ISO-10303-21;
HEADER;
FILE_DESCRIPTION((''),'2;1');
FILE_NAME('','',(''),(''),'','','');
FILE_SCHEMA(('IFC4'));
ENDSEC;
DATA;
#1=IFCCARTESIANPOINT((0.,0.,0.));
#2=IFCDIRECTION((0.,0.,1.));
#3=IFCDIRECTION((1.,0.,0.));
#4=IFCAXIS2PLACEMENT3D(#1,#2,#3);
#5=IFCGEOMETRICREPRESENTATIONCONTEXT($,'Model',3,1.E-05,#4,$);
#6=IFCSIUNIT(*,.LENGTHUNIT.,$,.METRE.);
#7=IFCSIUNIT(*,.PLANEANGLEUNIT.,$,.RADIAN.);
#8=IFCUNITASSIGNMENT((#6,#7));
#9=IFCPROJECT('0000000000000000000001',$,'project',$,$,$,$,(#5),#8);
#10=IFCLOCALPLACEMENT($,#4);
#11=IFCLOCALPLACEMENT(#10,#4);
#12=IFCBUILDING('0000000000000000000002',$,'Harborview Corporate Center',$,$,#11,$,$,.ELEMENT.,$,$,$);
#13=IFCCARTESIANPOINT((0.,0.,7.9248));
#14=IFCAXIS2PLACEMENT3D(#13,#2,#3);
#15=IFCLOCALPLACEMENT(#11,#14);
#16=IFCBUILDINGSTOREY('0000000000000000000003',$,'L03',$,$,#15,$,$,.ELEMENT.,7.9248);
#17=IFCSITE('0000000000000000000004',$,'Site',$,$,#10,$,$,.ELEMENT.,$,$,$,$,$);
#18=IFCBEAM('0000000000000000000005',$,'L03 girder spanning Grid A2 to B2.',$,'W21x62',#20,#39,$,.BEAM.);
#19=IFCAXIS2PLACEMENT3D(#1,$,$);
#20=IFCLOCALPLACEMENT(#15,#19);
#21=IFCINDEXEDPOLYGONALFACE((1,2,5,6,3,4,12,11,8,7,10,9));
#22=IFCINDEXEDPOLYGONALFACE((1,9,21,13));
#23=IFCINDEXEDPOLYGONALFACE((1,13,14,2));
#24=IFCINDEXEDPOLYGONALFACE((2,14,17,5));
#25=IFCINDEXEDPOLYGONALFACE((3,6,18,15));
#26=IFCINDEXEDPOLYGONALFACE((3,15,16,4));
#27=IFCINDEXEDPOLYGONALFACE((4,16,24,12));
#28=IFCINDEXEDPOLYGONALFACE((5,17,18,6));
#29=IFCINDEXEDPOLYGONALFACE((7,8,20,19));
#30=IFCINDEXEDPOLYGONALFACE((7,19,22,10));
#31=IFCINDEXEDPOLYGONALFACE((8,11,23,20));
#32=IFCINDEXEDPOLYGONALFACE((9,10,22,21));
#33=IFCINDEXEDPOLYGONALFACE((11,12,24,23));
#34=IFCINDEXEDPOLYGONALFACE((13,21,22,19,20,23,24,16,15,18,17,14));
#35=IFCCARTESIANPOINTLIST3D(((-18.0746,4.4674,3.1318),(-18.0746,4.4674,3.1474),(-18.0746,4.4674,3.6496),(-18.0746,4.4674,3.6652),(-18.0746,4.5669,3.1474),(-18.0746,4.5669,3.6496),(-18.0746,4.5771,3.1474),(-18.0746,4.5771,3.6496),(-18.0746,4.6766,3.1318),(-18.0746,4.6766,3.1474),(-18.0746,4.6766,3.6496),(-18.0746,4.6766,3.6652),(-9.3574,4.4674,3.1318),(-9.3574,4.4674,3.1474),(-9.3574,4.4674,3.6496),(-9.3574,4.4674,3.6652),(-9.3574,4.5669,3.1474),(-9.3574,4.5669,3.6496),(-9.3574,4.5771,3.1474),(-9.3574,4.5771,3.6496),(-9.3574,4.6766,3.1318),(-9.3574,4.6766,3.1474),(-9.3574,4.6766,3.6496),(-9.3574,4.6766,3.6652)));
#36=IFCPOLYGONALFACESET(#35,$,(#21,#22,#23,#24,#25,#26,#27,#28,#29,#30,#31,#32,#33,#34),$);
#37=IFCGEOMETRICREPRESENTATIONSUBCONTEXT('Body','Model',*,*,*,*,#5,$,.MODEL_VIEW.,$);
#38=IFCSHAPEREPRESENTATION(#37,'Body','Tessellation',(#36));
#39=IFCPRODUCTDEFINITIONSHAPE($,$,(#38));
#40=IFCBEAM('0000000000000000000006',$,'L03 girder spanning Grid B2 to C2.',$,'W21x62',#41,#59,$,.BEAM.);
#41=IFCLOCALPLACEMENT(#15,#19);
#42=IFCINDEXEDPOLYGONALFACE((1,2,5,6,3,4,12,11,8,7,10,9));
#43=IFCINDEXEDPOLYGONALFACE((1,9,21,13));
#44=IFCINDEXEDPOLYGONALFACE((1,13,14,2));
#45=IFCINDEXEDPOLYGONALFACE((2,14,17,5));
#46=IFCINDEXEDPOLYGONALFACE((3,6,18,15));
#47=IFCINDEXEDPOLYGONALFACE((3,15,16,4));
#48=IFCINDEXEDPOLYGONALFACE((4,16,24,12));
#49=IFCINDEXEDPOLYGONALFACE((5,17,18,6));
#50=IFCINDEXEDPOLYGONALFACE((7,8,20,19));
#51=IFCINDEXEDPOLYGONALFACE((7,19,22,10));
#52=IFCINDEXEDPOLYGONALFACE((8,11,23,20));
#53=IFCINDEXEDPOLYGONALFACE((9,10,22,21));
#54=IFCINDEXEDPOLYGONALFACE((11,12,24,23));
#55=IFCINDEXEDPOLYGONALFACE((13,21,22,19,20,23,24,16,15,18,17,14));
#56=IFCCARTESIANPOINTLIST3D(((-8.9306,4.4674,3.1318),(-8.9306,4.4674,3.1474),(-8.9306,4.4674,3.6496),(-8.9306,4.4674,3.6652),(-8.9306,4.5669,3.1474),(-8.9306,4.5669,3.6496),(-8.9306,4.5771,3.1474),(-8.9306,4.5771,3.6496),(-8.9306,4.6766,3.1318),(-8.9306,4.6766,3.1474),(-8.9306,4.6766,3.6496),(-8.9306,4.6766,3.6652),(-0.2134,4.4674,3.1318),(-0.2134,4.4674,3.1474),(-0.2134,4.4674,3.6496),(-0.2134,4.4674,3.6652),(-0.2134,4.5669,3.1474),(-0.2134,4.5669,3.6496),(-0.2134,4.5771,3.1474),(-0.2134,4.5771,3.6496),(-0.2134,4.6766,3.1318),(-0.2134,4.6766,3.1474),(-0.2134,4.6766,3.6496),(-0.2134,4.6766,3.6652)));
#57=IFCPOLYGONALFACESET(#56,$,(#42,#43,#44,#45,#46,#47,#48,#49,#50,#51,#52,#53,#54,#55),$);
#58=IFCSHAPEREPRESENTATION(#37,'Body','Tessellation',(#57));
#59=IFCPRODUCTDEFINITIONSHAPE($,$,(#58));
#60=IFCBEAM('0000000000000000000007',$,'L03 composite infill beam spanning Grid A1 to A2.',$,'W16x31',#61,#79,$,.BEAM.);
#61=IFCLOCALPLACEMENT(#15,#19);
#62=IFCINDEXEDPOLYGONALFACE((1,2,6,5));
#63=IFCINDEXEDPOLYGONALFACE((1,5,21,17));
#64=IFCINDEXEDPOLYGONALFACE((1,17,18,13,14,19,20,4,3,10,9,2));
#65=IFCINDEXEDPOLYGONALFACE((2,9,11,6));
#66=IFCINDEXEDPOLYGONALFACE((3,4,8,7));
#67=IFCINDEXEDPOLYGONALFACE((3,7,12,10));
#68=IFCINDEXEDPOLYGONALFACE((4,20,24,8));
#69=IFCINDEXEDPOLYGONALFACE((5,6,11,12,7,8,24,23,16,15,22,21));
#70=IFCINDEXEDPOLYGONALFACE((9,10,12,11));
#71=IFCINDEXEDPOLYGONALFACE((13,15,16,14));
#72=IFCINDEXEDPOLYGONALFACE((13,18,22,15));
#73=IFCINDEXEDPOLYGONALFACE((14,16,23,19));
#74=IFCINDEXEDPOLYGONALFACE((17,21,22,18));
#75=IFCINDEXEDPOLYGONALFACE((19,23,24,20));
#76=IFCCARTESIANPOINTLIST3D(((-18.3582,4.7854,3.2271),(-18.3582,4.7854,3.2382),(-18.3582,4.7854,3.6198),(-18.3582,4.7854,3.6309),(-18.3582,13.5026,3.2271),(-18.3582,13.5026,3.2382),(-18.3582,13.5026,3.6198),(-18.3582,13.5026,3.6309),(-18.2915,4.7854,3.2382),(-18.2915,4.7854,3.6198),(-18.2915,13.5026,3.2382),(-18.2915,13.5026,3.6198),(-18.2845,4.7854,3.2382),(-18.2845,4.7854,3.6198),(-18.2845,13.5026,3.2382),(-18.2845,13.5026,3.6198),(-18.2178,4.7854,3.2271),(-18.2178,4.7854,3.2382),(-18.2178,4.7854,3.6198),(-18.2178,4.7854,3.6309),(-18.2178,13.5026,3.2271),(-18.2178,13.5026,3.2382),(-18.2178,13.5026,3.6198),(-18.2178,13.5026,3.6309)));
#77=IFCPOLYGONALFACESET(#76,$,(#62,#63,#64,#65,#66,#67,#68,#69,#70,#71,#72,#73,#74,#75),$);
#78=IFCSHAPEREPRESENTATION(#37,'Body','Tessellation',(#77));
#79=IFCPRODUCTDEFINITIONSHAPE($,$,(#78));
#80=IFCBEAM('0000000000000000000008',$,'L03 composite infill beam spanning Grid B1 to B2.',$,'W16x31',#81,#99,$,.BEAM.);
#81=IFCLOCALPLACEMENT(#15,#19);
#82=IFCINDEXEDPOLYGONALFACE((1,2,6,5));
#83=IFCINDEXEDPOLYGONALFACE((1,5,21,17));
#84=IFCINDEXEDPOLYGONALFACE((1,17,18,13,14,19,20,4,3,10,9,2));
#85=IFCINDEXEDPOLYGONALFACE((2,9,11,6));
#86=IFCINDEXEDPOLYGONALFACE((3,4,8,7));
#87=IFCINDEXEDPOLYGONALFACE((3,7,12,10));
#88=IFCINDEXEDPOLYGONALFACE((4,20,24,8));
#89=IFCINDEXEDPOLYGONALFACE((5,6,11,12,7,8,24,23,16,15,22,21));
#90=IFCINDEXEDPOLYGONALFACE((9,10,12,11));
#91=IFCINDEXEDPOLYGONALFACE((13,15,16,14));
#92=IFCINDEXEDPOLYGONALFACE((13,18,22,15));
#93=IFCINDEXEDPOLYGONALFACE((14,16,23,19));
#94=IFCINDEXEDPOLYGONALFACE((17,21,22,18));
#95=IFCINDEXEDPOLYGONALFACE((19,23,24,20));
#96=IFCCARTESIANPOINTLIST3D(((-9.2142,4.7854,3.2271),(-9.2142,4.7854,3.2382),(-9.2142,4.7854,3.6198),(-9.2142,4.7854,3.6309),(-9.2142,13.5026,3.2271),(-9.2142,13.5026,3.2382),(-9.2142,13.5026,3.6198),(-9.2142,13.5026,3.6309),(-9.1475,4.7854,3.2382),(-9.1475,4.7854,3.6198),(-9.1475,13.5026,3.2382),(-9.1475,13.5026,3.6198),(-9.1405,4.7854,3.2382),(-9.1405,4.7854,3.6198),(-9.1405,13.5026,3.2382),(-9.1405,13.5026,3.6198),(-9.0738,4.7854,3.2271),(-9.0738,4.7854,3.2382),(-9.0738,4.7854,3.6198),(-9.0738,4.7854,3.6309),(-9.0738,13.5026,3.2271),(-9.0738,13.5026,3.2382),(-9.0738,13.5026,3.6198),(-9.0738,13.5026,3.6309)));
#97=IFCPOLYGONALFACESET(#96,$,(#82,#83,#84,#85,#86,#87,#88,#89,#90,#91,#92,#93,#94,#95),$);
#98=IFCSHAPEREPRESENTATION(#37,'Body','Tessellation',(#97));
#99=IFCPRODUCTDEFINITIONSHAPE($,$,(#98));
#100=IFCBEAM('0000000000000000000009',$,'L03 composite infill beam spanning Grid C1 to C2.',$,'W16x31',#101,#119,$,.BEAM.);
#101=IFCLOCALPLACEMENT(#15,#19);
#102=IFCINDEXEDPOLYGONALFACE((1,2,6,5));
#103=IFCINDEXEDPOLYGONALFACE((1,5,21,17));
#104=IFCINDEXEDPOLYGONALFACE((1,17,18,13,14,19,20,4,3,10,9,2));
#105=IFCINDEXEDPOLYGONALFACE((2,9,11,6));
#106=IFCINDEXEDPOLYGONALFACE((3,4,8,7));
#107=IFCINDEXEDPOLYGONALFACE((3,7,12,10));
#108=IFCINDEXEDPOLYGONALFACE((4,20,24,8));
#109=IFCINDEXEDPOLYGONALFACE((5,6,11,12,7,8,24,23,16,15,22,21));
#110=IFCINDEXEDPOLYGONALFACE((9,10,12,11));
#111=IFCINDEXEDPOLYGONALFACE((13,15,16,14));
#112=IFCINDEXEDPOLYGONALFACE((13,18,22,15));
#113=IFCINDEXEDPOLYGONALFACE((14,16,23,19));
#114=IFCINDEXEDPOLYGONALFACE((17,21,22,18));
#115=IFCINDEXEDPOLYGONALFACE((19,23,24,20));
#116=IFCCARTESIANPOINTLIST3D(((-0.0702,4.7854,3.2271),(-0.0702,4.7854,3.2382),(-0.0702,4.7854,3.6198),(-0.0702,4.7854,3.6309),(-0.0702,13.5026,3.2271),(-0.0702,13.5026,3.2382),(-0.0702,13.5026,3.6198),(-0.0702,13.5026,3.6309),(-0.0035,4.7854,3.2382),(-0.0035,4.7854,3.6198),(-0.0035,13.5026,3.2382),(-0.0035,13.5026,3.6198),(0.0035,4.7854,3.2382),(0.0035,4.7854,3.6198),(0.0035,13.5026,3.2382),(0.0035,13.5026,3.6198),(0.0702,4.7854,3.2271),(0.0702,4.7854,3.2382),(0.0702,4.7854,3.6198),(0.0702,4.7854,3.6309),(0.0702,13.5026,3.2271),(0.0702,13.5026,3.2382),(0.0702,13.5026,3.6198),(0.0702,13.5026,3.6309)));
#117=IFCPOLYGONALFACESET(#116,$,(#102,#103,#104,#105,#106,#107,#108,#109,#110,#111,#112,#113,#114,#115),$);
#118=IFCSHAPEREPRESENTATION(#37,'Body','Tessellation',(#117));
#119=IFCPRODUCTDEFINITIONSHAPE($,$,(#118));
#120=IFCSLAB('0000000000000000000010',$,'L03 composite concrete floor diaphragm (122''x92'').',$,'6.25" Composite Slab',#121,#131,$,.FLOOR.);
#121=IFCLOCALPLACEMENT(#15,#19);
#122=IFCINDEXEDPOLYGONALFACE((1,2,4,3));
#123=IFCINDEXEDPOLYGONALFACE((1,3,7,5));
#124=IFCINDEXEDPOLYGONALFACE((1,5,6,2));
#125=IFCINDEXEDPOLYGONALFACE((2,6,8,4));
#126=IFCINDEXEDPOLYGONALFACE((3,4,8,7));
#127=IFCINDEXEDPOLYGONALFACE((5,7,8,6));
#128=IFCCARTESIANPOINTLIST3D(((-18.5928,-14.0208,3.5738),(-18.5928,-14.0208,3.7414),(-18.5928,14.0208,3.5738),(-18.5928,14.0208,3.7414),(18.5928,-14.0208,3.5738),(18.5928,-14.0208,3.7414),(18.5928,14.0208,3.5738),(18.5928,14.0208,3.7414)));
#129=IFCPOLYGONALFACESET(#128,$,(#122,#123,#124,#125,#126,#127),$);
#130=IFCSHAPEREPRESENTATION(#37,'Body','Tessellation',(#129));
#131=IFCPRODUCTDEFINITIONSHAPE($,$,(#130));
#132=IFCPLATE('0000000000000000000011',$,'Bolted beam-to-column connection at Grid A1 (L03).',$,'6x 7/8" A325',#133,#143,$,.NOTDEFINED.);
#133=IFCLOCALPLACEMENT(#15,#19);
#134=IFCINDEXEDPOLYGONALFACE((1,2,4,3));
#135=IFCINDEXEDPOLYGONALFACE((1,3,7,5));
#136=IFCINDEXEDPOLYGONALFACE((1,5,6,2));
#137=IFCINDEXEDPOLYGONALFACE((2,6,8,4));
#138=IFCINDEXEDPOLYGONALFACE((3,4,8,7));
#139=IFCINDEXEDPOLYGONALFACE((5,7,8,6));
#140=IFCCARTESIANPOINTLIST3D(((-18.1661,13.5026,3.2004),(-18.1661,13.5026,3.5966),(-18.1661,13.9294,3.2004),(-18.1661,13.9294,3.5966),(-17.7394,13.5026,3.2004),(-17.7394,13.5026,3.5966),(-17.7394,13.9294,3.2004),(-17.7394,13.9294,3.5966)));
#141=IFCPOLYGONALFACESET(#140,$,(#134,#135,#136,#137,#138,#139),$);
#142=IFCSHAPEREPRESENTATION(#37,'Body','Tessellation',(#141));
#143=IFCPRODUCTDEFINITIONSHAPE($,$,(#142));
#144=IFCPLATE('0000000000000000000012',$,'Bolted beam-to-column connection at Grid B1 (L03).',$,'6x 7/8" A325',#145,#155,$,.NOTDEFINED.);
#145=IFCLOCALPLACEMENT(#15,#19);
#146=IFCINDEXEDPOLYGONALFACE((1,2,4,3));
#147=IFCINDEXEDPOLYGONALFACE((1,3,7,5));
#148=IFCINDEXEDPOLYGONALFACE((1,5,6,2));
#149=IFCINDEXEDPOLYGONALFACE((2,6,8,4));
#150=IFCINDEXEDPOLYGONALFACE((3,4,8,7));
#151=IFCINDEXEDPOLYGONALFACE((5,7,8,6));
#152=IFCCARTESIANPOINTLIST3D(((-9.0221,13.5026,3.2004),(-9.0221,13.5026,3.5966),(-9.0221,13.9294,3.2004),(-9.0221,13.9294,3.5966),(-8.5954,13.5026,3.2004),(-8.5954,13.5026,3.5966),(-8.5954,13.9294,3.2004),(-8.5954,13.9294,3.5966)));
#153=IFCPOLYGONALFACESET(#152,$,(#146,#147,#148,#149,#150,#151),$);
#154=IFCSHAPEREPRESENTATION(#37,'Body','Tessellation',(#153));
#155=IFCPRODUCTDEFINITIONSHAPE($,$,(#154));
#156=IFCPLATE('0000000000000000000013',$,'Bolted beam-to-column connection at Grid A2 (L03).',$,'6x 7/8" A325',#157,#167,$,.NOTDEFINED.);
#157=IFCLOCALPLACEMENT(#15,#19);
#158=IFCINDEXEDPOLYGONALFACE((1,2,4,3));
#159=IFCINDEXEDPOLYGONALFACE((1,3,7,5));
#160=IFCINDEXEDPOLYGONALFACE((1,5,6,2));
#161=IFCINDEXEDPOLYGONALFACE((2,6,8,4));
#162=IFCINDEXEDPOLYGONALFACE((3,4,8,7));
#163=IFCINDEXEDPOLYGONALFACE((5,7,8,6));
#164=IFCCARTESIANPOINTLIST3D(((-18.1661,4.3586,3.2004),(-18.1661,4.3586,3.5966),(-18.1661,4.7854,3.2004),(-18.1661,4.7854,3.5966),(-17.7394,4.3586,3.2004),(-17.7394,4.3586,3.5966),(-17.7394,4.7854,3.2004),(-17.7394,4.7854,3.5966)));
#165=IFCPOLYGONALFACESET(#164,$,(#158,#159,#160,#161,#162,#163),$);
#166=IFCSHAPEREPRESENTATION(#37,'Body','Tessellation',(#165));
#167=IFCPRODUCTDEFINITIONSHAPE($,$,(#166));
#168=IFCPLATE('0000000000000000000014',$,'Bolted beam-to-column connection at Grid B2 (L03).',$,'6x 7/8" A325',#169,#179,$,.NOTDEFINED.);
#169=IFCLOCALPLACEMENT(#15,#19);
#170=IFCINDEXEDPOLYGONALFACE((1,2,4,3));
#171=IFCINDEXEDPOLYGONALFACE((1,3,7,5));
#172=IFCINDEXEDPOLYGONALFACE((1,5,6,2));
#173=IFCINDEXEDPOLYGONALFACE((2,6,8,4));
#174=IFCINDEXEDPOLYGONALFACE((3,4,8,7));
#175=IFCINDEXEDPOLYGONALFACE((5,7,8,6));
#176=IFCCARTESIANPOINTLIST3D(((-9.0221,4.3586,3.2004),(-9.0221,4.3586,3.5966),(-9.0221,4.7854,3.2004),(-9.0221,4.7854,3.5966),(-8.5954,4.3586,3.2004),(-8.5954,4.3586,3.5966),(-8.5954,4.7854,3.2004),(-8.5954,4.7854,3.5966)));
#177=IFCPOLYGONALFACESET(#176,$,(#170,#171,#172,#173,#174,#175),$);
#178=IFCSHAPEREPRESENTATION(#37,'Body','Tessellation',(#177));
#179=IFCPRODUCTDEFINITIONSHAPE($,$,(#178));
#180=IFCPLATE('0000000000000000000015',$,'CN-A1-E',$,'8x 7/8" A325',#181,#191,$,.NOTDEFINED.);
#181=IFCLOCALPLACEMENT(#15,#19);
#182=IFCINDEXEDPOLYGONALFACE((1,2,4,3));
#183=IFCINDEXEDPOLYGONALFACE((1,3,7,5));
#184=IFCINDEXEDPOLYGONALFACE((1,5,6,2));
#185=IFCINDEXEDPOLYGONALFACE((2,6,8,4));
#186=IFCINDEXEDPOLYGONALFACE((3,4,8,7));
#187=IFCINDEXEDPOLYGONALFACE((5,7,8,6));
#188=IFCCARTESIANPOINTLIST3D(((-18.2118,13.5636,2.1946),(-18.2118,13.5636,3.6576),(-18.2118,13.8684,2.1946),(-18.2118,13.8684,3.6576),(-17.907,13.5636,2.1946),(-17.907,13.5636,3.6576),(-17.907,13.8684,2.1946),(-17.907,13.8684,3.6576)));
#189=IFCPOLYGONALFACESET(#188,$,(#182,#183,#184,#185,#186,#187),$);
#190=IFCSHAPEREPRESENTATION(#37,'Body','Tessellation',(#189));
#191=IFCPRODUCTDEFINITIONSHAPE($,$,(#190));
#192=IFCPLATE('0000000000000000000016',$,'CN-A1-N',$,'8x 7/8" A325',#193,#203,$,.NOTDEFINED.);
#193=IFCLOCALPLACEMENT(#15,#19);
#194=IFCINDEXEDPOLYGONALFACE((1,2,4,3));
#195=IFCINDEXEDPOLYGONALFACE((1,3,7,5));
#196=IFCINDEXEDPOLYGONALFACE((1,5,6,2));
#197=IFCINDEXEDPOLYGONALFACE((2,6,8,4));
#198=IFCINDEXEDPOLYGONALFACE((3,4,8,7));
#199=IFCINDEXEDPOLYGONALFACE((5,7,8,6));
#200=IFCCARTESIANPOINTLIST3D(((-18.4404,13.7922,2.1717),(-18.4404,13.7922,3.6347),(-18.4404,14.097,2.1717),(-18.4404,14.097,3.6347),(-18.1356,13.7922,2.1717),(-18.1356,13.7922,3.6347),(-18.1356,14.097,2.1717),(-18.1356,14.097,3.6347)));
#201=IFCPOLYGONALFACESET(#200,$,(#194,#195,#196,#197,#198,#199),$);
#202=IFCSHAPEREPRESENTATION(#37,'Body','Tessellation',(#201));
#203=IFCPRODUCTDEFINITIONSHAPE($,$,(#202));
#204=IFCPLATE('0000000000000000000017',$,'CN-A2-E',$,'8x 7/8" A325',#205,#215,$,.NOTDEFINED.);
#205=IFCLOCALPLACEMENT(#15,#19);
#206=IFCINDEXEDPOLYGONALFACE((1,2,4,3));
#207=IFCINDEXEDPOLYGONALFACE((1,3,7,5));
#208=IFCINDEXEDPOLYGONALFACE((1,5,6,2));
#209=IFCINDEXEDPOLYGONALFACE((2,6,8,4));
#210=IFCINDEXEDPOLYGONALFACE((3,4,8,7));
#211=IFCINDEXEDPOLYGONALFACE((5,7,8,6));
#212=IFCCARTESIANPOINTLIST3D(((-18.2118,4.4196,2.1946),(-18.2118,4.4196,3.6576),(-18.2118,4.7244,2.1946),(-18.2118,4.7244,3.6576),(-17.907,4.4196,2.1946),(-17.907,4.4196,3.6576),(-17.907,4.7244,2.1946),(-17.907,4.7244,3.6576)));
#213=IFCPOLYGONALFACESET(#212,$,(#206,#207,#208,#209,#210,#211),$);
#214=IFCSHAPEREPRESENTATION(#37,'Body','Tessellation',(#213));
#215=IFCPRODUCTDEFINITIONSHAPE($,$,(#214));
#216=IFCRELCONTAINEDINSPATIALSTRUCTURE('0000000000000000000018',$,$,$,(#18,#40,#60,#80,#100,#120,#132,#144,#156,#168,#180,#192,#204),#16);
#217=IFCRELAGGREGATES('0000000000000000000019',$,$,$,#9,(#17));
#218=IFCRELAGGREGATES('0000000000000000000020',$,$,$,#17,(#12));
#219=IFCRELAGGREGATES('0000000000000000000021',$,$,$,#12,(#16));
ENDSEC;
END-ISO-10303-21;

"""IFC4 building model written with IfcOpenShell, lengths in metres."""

from ifc_helpers import new_model, si_unit, frame, origin_with_axes, place, context, subcontext, project, spatial, rectangle, i_section, extrude, element, save


model = new_model("IFC4")

# Units and contexts
model_context = context("Model", 3, precision=1e-05, world=origin_with_axes())
body_context = subcontext(model_context, "Body", "Model", "MODEL_VIEW")
ifc_project = project(units=[si_unit("LENGTHUNIT", "METRE"), si_unit("PLANEANGLEUNIT", "RADIAN")], contexts=[model_context])

# Site, building, storey
site_placement = place(None, origin_with_axes())
site = spatial("IfcSite", under=ifc_project, at=site_placement, Name="Site", CompositionType="ELEMENT")
building_placement = place(site_placement, origin_with_axes())
building = spatial("IfcBuilding", under=site, at=building_placement, Name="Harborview Corporate Center", CompositionType="ELEMENT")
storey_placement = place(building_placement, frame((0.0, 0.0, 7.9248), z_axis=(0.0, 0.0, 1.0), x_axis=(1.0, 0.0, 0.0)))
storey = spatial("IfcBuildingStorey", under=building, at=storey_placement, Name="L03", CompositionType="ELEMENT", Elevation=7.9248)

# Beams
beam_1_placement = place(storey_placement, frame((-18.0746, 4.572, 3.3985), z_axis=(1.0, 0.0, 0.0), x_axis=(0.0, 1.0, 0.0)))
element("IfcBeam", 1, at=beam_1_placement, inside=storey, Name="L03 girder spanning Grid A2 to B2.", ObjectType="W21x62", PredefinedType="BEAM", context=body_context, shape_type="SweptSolid", body=[
    extrude(i_section(OverallWidth=0.2093, OverallDepth=0.5334, WebThickness=0.0102, FlangeThickness=0.0156), origin_with_axes(), (0.0, 0.0, 1.0), 8.7173),
])
beam_2_placement = place(storey_placement, frame((-8.9306, 4.572, 3.3985), z_axis=(1.0, 0.0, 0.0), x_axis=(0.0, 1.0, 0.0)))
element("IfcBeam", 2, at=beam_2_placement, inside=storey, Name="L03 girder spanning Grid B2 to C2.", ObjectType="W21x62", PredefinedType="BEAM", context=body_context, shape_type="SweptSolid", body=[
    extrude(i_section(OverallWidth=0.2093, OverallDepth=0.5334, WebThickness=0.0102, FlangeThickness=0.0156), origin_with_axes(), (0.0, 0.0, 1.0), 8.7173),
])
for number, where, z_axis, x_axis, name in (
    (3, (-18.288, 4.7854, 3.429), (0.0, 1.0, 0.0), (-1.0, 0.0, 0.0), "L03 composite infill beam spanning Grid A1 to A2."),
    (4, (-9.144, 4.7854, 3.429), (0.0, 1.0, 0.0), (-1.0, 0.0, 0.0), "L03 composite infill beam spanning Grid B1 to B2."),
    (5, (0.0, 4.7854, 3.429), (0.0, 1.0, 0.0), (-1.0, 0.0, 0.0), "L03 composite infill beam spanning Grid C1 to C2."),
):
    element("IfcBeam", number, at=place(storey_placement, frame(where, z_axis=z_axis, x_axis=x_axis)), inside=storey, Name=name, ObjectType="W16x31", PredefinedType="BEAM", context=body_context, shape_type="SweptSolid", body=[
        extrude(i_section(OverallWidth=0.1405, OverallDepth=0.4039, WebThickness=0.007, FlangeThickness=0.0112), origin_with_axes(), (0.0, 0.0, 1.0), 8.7173),
    ])

# Slab
slab_placement = place(storey_placement, frame((0.0, 0.0, 3.5738), z_axis=(0.0, 0.0, 1.0), x_axis=(1.0, 0.0, 0.0)))
element("IfcSlab", 6, at=slab_placement, inside=storey, Name="L03 composite concrete floor diaphragm (122'x92').", ObjectType="6.25\" Composite Slab", PredefinedType="FLOOR", context=body_context, shape_type="SweptSolid", body=[
    extrude(rectangle(XDim=37.1856, YDim=28.0416), origin_with_axes(), (0.0, 0.0, 1.0), 0.1676),
])

# Plates
plate_1_placement = place(storey_placement, frame((-17.9527, 13.716, 3.2004), z_axis=(0.0, 0.0, 1.0), x_axis=(1.0, 0.0, 0.0)))
element("IfcPlate", 7, at=plate_1_placement, inside=storey, Name="Bolted beam-to-column connection at Grid A1 (L03).", ObjectType="6x 7/8\" A325", PredefinedType="NOTDEFINED", context=body_context, shape_type="SweptSolid", body=[
    extrude(rectangle(XDim=0.4267, YDim=0.4267), origin_with_axes(), (0.0, 0.0, 1.0), 0.3962),
])
plate_2_placement = place(storey_placement, frame((-8.8087, 13.716, 3.2004), z_axis=(0.0, 0.0, 1.0), x_axis=(1.0, 0.0, 0.0)))
element("IfcPlate", 8, at=plate_2_placement, inside=storey, Name="Bolted beam-to-column connection at Grid B1 (L03).", ObjectType="6x 7/8\" A325", PredefinedType="NOTDEFINED", context=body_context, shape_type="SweptSolid", body=[
    extrude(rectangle(XDim=0.4267, YDim=0.4267), origin_with_axes(), (0.0, 0.0, 1.0), 0.3962),
])
plate_3_placement = place(storey_placement, frame((-17.9527, 4.572, 3.2004), z_axis=(0.0, 0.0, 1.0), x_axis=(1.0, 0.0, 0.0)))
element("IfcPlate", 9, at=plate_3_placement, inside=storey, Name="Bolted beam-to-column connection at Grid A2 (L03).", ObjectType="6x 7/8\" A325", PredefinedType="NOTDEFINED", context=body_context, shape_type="SweptSolid", body=[
    extrude(rectangle(XDim=0.4267, YDim=0.4267), origin_with_axes(), (0.0, 0.0, 1.0), 0.3962),
])
plate_4_placement = place(storey_placement, frame((-8.8087, 4.572, 3.2004), z_axis=(0.0, 0.0, 1.0), x_axis=(1.0, 0.0, 0.0)))
element("IfcPlate", 10, at=plate_4_placement, inside=storey, Name="Bolted beam-to-column connection at Grid B2 (L03).", ObjectType="6x 7/8\" A325", PredefinedType="NOTDEFINED", context=body_context, shape_type="SweptSolid", body=[
    extrude(rectangle(XDim=0.4267, YDim=0.4267), origin_with_axes(), (0.0, 0.0, 1.0), 0.3962),
])
for number, where, z_axis, x_axis, name in (
    (11, (-18.0594, 13.716, 2.1946), (0.0, 0.0, 1.0), (1.0, 0.0, 0.0), "CN-A1-E"),
    (12, (-18.288, 13.9446, 2.1717), (0.0, 0.0, 1.0), (1.0, 0.0, 0.0), "CN-A1-N"),
    (13, (-18.0594, 4.572, 2.1946), (0.0, 0.0, 1.0), (1.0, 0.0, 0.0), "CN-A2-E"),
):
    element("IfcPlate", number, at=place(storey_placement, frame(where, z_axis=z_axis, x_axis=x_axis)), inside=storey, Name=name, ObjectType="8x 7/8\" A325", PredefinedType="NOTDEFINED", context=body_context, shape_type="SweptSolid", body=[
        extrude(rectangle(XDim=0.3048, YDim=0.3048), origin_with_axes(), (0.0, 0.0, 1.0), 1.463),
    ])

save(model, "model.ifc")
